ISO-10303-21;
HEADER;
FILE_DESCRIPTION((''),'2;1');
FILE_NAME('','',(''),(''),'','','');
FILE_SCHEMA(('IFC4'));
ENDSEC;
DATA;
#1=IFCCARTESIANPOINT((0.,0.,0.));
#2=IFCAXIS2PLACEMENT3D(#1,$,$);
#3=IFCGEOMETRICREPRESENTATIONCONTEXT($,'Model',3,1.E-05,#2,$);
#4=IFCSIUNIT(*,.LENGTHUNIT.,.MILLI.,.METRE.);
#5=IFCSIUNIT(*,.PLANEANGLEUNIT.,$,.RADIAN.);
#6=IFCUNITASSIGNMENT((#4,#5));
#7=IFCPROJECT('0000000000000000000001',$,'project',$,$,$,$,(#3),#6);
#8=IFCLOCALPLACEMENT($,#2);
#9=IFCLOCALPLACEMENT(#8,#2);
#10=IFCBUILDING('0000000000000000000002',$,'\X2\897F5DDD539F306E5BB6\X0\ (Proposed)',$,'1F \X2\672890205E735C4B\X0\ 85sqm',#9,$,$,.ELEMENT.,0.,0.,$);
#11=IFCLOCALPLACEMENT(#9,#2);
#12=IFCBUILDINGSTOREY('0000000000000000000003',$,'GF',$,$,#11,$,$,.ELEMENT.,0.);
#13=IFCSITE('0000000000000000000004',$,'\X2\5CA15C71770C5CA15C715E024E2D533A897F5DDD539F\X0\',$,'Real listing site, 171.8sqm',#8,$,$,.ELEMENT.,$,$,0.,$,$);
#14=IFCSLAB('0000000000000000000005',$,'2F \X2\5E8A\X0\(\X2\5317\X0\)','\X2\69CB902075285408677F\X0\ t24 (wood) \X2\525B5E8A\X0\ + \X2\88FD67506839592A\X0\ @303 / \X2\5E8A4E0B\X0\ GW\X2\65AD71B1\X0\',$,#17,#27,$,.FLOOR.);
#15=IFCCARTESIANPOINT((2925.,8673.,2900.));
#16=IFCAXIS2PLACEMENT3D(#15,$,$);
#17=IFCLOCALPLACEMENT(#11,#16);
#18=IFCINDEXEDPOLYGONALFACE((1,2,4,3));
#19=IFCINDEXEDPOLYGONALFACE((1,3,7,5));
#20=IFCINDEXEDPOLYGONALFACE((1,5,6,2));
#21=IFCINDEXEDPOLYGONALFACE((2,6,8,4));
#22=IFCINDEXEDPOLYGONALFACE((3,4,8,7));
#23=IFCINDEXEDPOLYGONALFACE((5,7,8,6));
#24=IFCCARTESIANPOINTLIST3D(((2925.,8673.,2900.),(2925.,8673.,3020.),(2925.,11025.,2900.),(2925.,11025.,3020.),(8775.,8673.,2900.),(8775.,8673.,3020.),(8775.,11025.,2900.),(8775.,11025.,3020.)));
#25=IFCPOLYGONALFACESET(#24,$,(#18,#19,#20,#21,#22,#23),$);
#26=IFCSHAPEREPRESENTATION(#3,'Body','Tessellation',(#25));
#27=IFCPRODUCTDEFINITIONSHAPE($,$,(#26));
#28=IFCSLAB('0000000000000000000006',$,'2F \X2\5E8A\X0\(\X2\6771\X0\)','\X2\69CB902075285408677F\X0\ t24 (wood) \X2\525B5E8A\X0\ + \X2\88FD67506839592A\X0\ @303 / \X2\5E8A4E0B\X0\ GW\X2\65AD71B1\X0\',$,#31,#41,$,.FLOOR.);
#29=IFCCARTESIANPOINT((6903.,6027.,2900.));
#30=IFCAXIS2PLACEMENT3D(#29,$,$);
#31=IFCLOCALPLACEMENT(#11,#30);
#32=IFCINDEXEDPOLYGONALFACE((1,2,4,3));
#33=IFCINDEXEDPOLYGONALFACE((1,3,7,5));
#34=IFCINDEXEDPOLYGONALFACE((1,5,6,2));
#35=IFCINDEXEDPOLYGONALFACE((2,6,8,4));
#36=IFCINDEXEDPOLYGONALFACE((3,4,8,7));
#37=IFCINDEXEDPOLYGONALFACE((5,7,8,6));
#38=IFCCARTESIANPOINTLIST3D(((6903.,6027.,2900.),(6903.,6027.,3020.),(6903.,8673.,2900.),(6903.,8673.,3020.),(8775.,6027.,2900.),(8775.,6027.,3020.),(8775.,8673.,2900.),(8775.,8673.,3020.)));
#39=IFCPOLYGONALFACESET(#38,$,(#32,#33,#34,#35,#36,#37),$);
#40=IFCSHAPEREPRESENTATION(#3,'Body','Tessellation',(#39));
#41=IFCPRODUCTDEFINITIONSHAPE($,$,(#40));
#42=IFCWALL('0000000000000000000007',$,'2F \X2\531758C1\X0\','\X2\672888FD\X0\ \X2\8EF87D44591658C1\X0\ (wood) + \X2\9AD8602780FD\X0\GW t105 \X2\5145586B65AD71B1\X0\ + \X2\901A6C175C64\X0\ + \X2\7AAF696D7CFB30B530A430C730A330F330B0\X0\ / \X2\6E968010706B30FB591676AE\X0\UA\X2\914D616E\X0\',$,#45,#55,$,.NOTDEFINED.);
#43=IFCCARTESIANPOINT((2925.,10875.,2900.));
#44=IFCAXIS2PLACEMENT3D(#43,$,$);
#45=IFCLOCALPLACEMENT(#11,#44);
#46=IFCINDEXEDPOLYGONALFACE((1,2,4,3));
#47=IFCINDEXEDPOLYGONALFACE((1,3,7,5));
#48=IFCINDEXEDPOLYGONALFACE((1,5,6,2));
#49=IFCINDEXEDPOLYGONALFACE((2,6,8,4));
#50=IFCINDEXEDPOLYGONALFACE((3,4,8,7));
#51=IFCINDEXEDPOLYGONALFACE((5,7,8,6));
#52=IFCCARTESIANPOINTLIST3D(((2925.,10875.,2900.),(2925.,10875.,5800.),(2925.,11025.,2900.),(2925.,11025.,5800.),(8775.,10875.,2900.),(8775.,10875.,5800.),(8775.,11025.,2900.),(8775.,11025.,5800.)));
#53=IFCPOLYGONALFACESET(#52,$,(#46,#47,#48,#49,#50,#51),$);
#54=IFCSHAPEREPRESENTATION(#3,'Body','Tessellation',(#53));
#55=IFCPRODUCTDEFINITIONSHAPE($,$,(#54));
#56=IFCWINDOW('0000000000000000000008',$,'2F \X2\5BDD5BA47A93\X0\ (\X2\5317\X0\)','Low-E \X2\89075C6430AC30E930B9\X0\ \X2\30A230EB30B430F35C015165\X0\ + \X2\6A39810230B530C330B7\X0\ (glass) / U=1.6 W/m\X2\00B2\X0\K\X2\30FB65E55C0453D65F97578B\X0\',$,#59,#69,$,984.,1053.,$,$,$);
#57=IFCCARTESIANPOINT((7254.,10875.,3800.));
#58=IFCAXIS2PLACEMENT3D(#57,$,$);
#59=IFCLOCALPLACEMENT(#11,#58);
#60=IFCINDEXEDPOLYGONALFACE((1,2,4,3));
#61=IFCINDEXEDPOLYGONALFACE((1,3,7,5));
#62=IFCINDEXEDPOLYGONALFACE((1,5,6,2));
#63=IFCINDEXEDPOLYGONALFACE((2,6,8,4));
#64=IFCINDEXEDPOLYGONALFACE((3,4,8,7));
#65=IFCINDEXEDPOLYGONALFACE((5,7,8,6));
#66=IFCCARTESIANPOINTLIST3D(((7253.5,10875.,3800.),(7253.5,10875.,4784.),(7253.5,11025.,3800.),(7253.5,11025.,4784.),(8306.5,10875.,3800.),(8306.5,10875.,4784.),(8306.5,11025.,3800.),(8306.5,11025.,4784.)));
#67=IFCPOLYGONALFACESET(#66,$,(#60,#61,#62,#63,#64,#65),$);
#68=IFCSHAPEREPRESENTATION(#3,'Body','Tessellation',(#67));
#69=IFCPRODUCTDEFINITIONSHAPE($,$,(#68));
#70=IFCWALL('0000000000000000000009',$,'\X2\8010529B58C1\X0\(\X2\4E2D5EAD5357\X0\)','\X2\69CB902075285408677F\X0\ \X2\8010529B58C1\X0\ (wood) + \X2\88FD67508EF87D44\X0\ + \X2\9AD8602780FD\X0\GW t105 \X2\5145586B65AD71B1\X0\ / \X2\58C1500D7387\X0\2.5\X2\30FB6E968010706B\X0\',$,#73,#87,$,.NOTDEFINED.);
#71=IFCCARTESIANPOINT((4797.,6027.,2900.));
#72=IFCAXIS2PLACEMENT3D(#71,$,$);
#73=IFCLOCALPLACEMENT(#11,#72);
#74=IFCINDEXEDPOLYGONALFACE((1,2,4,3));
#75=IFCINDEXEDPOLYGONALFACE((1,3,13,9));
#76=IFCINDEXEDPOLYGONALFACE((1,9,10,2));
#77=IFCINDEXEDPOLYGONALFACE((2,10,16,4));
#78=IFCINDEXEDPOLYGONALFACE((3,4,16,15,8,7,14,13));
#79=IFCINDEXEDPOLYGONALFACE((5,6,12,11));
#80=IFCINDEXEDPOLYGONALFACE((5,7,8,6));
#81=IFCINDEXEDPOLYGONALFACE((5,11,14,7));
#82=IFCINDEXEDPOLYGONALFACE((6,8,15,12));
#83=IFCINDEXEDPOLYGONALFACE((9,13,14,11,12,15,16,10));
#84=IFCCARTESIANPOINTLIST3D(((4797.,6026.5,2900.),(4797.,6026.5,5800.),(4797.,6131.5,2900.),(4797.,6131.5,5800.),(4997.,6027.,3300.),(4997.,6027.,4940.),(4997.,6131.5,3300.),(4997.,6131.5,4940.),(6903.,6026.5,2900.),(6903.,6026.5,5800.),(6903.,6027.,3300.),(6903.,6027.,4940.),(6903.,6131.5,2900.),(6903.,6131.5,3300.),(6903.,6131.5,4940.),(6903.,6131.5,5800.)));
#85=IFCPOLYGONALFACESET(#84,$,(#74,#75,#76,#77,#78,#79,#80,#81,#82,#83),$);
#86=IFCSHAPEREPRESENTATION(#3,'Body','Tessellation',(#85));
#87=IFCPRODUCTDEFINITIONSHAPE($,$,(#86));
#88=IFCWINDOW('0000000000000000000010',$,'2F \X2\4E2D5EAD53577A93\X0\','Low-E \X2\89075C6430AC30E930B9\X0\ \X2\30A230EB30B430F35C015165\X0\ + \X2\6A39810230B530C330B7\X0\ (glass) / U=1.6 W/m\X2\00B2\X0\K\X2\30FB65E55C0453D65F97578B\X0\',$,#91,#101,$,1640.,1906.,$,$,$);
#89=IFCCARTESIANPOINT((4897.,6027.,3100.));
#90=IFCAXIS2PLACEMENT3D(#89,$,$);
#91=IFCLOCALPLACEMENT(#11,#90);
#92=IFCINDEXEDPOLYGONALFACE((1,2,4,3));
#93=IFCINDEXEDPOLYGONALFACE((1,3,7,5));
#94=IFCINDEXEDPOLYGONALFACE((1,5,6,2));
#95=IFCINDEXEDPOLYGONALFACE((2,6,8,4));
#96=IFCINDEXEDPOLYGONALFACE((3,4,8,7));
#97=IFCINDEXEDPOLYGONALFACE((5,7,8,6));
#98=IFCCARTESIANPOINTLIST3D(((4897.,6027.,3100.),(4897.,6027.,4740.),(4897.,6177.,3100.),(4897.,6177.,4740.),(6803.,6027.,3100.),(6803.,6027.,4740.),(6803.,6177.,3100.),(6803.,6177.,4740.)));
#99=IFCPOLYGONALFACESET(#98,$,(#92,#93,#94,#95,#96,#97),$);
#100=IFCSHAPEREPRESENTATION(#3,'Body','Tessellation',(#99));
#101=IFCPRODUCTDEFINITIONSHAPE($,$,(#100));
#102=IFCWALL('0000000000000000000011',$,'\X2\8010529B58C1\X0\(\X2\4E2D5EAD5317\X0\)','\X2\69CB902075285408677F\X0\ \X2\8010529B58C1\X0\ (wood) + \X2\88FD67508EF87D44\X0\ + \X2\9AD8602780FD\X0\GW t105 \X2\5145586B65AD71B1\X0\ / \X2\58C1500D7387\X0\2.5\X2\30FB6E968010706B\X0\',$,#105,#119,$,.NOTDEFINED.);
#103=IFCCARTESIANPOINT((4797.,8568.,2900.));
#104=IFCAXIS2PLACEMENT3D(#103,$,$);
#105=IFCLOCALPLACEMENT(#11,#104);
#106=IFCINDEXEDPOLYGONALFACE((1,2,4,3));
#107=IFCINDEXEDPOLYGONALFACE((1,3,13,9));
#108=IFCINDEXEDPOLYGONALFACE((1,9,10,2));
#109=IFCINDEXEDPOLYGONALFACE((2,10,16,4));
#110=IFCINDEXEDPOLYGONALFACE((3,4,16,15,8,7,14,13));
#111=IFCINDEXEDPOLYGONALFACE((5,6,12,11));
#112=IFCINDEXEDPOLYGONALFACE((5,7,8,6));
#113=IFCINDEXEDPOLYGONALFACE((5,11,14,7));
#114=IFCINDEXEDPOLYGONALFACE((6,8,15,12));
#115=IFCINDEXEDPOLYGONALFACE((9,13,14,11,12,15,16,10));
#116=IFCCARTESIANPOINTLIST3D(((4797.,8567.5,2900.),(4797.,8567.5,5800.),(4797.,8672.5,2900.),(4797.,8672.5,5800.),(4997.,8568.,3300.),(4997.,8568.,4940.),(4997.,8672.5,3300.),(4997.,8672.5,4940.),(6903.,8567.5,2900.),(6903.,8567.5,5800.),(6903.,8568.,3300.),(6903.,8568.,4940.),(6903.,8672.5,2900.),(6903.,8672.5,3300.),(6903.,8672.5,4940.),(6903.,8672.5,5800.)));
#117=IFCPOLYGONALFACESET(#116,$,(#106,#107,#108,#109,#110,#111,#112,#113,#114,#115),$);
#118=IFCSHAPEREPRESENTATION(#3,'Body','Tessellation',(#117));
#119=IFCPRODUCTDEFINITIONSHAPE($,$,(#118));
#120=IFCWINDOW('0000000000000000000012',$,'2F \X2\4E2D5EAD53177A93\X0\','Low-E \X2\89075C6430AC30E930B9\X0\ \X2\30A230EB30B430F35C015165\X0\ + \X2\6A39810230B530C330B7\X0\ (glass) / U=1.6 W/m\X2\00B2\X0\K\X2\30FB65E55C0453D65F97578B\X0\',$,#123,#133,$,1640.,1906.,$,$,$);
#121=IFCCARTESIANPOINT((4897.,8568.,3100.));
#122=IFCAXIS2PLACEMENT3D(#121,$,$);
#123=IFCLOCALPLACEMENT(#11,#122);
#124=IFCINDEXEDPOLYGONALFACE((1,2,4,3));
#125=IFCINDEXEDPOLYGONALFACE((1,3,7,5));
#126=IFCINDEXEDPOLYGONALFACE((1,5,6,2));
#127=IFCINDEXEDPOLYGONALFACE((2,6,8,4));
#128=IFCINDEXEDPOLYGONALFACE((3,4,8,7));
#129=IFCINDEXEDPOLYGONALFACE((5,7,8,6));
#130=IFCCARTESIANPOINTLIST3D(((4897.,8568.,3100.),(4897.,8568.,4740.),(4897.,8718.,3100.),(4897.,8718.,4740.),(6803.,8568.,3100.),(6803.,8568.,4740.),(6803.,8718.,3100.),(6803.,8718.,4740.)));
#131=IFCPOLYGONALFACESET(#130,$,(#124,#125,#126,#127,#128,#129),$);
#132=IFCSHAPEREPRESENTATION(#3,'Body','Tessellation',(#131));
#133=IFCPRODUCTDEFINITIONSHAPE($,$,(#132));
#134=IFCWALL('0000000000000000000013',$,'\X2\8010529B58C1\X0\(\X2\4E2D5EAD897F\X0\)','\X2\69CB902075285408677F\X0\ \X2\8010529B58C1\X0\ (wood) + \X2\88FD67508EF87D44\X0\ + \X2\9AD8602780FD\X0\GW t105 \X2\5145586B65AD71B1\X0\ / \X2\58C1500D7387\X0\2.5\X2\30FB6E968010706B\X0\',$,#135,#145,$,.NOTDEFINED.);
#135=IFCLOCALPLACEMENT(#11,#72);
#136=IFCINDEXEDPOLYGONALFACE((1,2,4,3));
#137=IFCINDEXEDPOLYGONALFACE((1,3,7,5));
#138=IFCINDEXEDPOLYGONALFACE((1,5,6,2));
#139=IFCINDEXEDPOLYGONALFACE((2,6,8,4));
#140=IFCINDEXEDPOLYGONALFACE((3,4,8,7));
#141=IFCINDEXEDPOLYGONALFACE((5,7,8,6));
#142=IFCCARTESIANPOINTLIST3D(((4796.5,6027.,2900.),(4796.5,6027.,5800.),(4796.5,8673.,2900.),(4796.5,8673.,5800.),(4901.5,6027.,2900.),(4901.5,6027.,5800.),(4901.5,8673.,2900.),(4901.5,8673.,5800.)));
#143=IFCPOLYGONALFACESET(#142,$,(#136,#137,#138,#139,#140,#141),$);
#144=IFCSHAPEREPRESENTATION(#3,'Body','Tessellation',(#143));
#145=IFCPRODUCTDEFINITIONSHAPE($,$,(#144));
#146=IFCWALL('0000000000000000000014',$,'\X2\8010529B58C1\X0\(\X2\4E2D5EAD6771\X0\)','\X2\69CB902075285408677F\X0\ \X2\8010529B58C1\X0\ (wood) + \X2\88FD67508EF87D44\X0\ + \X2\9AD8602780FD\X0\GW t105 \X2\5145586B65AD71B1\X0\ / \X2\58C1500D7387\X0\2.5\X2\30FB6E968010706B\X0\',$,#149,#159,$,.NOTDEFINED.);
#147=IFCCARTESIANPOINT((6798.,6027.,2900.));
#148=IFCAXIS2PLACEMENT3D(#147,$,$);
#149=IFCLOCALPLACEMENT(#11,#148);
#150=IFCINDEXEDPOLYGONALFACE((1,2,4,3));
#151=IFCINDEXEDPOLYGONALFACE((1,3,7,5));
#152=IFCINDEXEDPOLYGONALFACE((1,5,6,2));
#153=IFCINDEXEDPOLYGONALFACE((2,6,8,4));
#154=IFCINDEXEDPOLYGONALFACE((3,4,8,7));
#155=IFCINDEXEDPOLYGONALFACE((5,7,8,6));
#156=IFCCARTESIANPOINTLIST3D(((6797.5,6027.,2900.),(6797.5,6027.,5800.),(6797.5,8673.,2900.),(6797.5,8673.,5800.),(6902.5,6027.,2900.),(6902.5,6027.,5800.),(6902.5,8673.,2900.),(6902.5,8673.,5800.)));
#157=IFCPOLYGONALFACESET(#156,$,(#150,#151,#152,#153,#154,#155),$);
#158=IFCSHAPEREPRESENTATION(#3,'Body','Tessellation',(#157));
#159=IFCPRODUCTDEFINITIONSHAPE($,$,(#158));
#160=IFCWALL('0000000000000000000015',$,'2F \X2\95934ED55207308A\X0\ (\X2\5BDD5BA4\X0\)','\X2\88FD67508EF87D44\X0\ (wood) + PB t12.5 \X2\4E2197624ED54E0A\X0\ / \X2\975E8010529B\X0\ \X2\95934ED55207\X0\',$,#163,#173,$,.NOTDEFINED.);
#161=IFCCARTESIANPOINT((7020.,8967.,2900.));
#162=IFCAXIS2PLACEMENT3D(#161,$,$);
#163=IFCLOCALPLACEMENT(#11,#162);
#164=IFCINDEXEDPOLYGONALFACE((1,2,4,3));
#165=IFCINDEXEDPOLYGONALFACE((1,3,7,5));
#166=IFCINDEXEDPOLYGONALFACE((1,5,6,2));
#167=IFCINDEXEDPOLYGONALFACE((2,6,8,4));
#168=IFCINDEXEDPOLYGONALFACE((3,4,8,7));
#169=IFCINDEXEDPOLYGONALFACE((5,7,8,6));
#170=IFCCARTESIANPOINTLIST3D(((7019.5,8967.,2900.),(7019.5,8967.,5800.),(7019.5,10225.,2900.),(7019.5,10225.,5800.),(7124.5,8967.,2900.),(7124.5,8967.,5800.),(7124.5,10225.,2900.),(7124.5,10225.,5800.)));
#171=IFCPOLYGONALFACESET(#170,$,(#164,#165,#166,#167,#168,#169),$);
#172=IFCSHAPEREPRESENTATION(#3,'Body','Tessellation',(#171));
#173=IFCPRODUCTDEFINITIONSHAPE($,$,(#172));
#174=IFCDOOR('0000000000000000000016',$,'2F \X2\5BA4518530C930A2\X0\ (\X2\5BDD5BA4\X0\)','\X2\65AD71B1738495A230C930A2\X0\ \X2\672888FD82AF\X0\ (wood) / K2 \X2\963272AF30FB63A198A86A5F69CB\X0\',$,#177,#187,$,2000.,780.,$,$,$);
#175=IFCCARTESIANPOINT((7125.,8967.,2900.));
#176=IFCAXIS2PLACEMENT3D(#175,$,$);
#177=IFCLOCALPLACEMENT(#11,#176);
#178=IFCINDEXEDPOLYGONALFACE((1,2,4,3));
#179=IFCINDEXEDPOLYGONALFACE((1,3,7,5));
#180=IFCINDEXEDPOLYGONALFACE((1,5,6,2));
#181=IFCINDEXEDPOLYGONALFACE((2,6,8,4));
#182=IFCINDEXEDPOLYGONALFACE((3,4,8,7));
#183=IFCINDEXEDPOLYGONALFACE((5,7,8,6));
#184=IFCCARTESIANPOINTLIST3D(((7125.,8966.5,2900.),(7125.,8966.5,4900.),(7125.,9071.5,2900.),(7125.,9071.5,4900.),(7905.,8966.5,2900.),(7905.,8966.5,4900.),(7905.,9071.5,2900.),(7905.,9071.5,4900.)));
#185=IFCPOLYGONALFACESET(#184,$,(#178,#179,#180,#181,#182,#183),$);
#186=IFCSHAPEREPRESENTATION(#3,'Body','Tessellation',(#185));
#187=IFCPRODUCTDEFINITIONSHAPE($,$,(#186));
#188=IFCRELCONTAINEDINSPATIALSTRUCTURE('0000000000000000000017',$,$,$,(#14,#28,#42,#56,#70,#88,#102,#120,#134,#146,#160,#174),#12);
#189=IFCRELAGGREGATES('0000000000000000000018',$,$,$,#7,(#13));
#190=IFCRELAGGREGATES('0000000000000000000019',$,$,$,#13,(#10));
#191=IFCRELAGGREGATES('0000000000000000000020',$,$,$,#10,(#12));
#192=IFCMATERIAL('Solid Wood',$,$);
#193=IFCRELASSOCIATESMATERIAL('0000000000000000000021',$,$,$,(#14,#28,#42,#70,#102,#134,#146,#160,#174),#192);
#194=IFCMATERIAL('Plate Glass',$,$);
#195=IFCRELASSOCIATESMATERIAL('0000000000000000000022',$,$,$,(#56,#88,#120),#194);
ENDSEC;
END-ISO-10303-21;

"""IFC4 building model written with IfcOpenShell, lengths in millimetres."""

from ifc_helpers import new_model, si_unit, frame, frame_2d, origin, place, context, project, spatial, rectangle, extrude, material, element, fill, save


model = new_model("IFC4")

# Units and contexts
model_context = context("Model", 3, precision=1e-05, world=origin())
ifc_project = project(units=[si_unit("LENGTHUNIT", "METRE", prefix="MILLI"), si_unit("PLANEANGLEUNIT", "RADIAN")], contexts=[model_context])

# Site, building, storey
site_placement = place(None, origin())
site = spatial("IfcSite", under=ifc_project, at=site_placement, Name="岡山県岡山市中区西川原", ObjectType="Real listing site, 171.8sqm", CompositionType="ELEMENT", RefElevation=0.0)
building_placement = place(site_placement, origin())
building = spatial("IfcBuilding", under=site, at=building_placement, Name="西川原の家 (Proposed)", ObjectType="1F 木造平屋 85sqm", CompositionType="ELEMENT", ElevationOfRefHeight=0.0, ElevationOfTerrain=0.0)
storey_placement = place(building_placement, origin())
storey = spatial("IfcBuildingStorey", under=building, at=storey_placement, Name="GF", CompositionType="ELEMENT", Elevation=0.0)

# Slabs
ifc_material_1 = material(Name="Solid Wood")
slab_1_placement = place(storey_placement, frame((2925.0, 8673.0, 2900.0)))
element("IfcSlab", 1, at=slab_1_placement, inside=storey, material=ifc_material_1, Name="2F 床(北)", Description="構造用合板 t24 (wood) 剛床 + 製材根太 @303 / 床下 GW断熱", PredefinedType="FLOOR", context=model_context, shape_type="SweptSolid", body=[
    extrude(rectangle(XDim=5850.0, YDim=2352.0, at=frame_2d((2925.0, 1176.0))), frame((2925.0, 8673.0, 2900.0)), (0.0, 0.0, 1.0), 120.0),
])
slab_2_placement = place(storey_placement, frame((6903.0, 6027.0, 2900.0)))
element("IfcSlab", 2, at=slab_2_placement, inside=storey, material=ifc_material_1, Name="2F 床(東)", Description="構造用合板 t24 (wood) 剛床 + 製材根太 @303 / 床下 GW断熱", PredefinedType="FLOOR", context=model_context, shape_type="SweptSolid", body=[
    extrude(rectangle(XDim=1872.0, YDim=2646.0, at=frame_2d((936.0, 1323.0))), frame((6903.0, 6027.0, 2900.0)), (0.0, 0.0, 1.0), 120.0),
])

# Walls, openings, windows
wall_1_placement = place(storey_placement, frame((2925.0, 10875.0, 2900.0)))
wall_1 = element("IfcWall", 3, at=wall_1_placement, inside=storey, material=ifc_material_1, Name="2F 北壁", Description="木製 軸組外壁 (wood) + 高性能GW t105 充填断熱 + 通気層 + 窯業系サイディング / 準耐火・外皮UA配慮", PredefinedType="NOTDEFINED", context=model_context, shape_type="SweptSolid", body=[
    extrude(rectangle(XDim=5850.0, YDim=150.0, at=frame_2d((2925.0, 75.0))), frame((2925.0, 10875.0, 2900.0)), (0.0, 0.0, 1.0), 2900.0),
])
opening_1_placement = place(storey_placement, frame((7254.0, 10875.0, 3800.0)))
opening_1 = element("IfcOpeningElement", 4, at=opening_1_placement, cuts=wall_1, PredefinedType="NOTDEFINED", context=model_context, shape_type="SweptSolid", body=[
    extrude(rectangle(XDim=1053.0, YDim=150.0, at=frame_2d((526.0, 75.0))), frame((7254.0, 10875.0, 3800.0)), (0.0, 0.0, 1.0), 984.0),
])
ifc_material_2 = material(Name="Plate Glass")
window_1_placement = place(storey_placement, frame((7254.0, 10875.0, 3800.0)))
window_1 = element("IfcWindow", 5, at=window_1_placement, inside=storey, material=ifc_material_2, Name="2F 寝室窓 (北)", Description="Low-E 複層ガラス アルゴン封入 + 樹脂サッシ (glass) / U=1.6 W/m²K・日射取得型", OverallHeight=984.0, OverallWidth=1053.0, context=model_context, shape_type="SweptSolid", body=[
    extrude(rectangle(XDim=1053.0, YDim=150.0, at=frame_2d((526.0, 75.0))), frame((7254.0, 10875.0, 3800.0)), (0.0, 0.0, 1.0), 984.0),
])
fill(opening_1, window_1)
wall_2_placement = place(storey_placement, frame((4797.0, 6027.0, 2900.0)))
wall_2 = element("IfcWall", 6, at=wall_2_placement, inside=storey, material=ifc_material_1, Name="耐力壁(中庭南)", Description="構造用合板 耐力壁 (wood) + 製材軸組 + 高性能GW t105 充填断熱 / 壁倍率2.5・準耐火", PredefinedType="NOTDEFINED", context=model_context, shape_type="SweptSolid", body=[
    extrude(rectangle(XDim=2106.0, YDim=105.0, at=frame_2d((1053.0, 52.0))), frame((4797.0, 6027.0, 2900.0)), (0.0, 0.0, 1.0), 2900.0),
])
opening_2_placement = place(storey_placement, frame((4897.0, 6027.0, 3100.0)))
opening_2 = element("IfcOpeningElement", 7, at=opening_2_placement, cuts=wall_2, PredefinedType="NOTDEFINED", context=model_context, shape_type="SweptSolid", body=[
    extrude(rectangle(XDim=1906.0, YDim=150.0, at=frame_2d((953.0, 75.0))), frame((4897.0, 6027.0, 3100.0)), (0.0, 0.0, 1.0), 1640.0),
])
window_2_placement = place(storey_placement, frame((4897.0, 6027.0, 3100.0)))
window_2 = element("IfcWindow", 8, at=window_2_placement, inside=storey, material=ifc_material_2, Name="2F 中庭南窓", Description="Low-E 複層ガラス アルゴン封入 + 樹脂サッシ (glass) / U=1.6 W/m²K・日射取得型", OverallHeight=1640.0, OverallWidth=1906.0, context=model_context, shape_type="SweptSolid", body=[
    extrude(rectangle(XDim=1906.0, YDim=150.0, at=frame_2d((953.0, 75.0))), frame((4897.0, 6027.0, 3100.0)), (0.0, 0.0, 1.0), 1640.0),
])
fill(opening_2, window_2)
wall_3_placement = place(storey_placement, frame((4797.0, 8568.0, 2900.0)))
wall_3 = element("IfcWall", 9, at=wall_3_placement, inside=storey, material=ifc_material_1, Name="耐力壁(中庭北)", Description="構造用合板 耐力壁 (wood) + 製材軸組 + 高性能GW t105 充填断熱 / 壁倍率2.5・準耐火", PredefinedType="NOTDEFINED", context=model_context, shape_type="SweptSolid", body=[
    extrude(rectangle(XDim=2106.0, YDim=105.0, at=frame_2d((1053.0, 52.0))), frame((4797.0, 8568.0, 2900.0)), (0.0, 0.0, 1.0), 2900.0),
])
opening_3_placement = place(storey_placement, frame((4897.0, 8568.0, 3100.0)))
opening_3 = element("IfcOpeningElement", 10, at=opening_3_placement, cuts=wall_3, PredefinedType="NOTDEFINED", context=model_context, shape_type="SweptSolid", body=[
    extrude(rectangle(XDim=1906.0, YDim=150.0, at=frame_2d((953.0, 75.0))), frame((4897.0, 8568.0, 3100.0)), (0.0, 0.0, 1.0), 1640.0),
])
window_3_placement = place(storey_placement, frame((4897.0, 8568.0, 3100.0)))
window_3 = element("IfcWindow", 11, at=window_3_placement, inside=storey, material=ifc_material_2, Name="2F 中庭北窓", Description="Low-E 複層ガラス アルゴン封入 + 樹脂サッシ (glass) / U=1.6 W/m²K・日射取得型", OverallHeight=1640.0, OverallWidth=1906.0, context=model_context, shape_type="SweptSolid", body=[
    extrude(rectangle(XDim=1906.0, YDim=150.0, at=frame_2d((953.0, 75.0))), frame((4897.0, 8568.0, 3100.0)), (0.0, 0.0, 1.0), 1640.0),
])
fill(opening_3, window_3)

# Walls
wall_4_placement = place(storey_placement, frame((4797.0, 6027.0, 2900.0)))
element("IfcWall", 12, at=wall_4_placement, inside=storey, material=ifc_material_1, Name="耐力壁(中庭西)", Description="構造用合板 耐力壁 (wood) + 製材軸組 + 高性能GW t105 充填断熱 / 壁倍率2.5・準耐火", PredefinedType="NOTDEFINED", context=model_context, shape_type="SweptSolid", body=[
    extrude(rectangle(XDim=105.0, YDim=2646.0, at=frame_2d((52.0, 1323.0))), frame((4797.0, 6027.0, 2900.0)), (0.0, 0.0, 1.0), 2900.0),
])
wall_5_placement = place(storey_placement, frame((6798.0, 6027.0, 2900.0)))
element("IfcWall", 13, at=wall_5_placement, inside=storey, material=ifc_material_1, Name="耐力壁(中庭東)", Description="構造用合板 耐力壁 (wood) + 製材軸組 + 高性能GW t105 充填断熱 / 壁倍率2.5・準耐火", PredefinedType="NOTDEFINED", context=model_context, shape_type="SweptSolid", body=[
    extrude(rectangle(XDim=105.0, YDim=2646.0, at=frame_2d((52.0, 1323.0))), frame((6798.0, 6027.0, 2900.0)), (0.0, 0.0, 1.0), 2900.0),
])
wall_6_placement = place(storey_placement, frame((7020.0, 8967.0, 2900.0)))
element("IfcWall", 14, at=wall_6_placement, inside=storey, material=ifc_material_1, Name="2F 間仕切り (寝室)", Description="製材軸組 (wood) + PB t12.5 両面仕上 / 非耐力 間仕切", PredefinedType="NOTDEFINED", context=model_context, shape_type="SweptSolid", body=[
    extrude(rectangle(XDim=105.0, YDim=1258.0, at=frame_2d((52.0, 629.0))), frame((7020.0, 8967.0, 2900.0)), (0.0, 0.0, 1.0), 2900.0),
])

# Door
door_placement = place(storey_placement, frame((7125.0, 8967.0, 2900.0)))
element("IfcDoor", 15, at=door_placement, inside=storey, material=ifc_material_1, Name="2F 室内ドア (寝室)", Description="断熱玄関ドア 木製芯 (wood) / K2 防犯・採風機構", OverallHeight=2000.0, OverallWidth=780.0, context=model_context, shape_type="SweptSolid", body=[
    extrude(rectangle(XDim=780.0, YDim=105.0, at=frame_2d((390.0, 52.0))), frame((7125.0, 8967.0, 2900.0)), (0.0, 0.0, 1.0), 2000.0),
])

save(model, "model.ifc")
